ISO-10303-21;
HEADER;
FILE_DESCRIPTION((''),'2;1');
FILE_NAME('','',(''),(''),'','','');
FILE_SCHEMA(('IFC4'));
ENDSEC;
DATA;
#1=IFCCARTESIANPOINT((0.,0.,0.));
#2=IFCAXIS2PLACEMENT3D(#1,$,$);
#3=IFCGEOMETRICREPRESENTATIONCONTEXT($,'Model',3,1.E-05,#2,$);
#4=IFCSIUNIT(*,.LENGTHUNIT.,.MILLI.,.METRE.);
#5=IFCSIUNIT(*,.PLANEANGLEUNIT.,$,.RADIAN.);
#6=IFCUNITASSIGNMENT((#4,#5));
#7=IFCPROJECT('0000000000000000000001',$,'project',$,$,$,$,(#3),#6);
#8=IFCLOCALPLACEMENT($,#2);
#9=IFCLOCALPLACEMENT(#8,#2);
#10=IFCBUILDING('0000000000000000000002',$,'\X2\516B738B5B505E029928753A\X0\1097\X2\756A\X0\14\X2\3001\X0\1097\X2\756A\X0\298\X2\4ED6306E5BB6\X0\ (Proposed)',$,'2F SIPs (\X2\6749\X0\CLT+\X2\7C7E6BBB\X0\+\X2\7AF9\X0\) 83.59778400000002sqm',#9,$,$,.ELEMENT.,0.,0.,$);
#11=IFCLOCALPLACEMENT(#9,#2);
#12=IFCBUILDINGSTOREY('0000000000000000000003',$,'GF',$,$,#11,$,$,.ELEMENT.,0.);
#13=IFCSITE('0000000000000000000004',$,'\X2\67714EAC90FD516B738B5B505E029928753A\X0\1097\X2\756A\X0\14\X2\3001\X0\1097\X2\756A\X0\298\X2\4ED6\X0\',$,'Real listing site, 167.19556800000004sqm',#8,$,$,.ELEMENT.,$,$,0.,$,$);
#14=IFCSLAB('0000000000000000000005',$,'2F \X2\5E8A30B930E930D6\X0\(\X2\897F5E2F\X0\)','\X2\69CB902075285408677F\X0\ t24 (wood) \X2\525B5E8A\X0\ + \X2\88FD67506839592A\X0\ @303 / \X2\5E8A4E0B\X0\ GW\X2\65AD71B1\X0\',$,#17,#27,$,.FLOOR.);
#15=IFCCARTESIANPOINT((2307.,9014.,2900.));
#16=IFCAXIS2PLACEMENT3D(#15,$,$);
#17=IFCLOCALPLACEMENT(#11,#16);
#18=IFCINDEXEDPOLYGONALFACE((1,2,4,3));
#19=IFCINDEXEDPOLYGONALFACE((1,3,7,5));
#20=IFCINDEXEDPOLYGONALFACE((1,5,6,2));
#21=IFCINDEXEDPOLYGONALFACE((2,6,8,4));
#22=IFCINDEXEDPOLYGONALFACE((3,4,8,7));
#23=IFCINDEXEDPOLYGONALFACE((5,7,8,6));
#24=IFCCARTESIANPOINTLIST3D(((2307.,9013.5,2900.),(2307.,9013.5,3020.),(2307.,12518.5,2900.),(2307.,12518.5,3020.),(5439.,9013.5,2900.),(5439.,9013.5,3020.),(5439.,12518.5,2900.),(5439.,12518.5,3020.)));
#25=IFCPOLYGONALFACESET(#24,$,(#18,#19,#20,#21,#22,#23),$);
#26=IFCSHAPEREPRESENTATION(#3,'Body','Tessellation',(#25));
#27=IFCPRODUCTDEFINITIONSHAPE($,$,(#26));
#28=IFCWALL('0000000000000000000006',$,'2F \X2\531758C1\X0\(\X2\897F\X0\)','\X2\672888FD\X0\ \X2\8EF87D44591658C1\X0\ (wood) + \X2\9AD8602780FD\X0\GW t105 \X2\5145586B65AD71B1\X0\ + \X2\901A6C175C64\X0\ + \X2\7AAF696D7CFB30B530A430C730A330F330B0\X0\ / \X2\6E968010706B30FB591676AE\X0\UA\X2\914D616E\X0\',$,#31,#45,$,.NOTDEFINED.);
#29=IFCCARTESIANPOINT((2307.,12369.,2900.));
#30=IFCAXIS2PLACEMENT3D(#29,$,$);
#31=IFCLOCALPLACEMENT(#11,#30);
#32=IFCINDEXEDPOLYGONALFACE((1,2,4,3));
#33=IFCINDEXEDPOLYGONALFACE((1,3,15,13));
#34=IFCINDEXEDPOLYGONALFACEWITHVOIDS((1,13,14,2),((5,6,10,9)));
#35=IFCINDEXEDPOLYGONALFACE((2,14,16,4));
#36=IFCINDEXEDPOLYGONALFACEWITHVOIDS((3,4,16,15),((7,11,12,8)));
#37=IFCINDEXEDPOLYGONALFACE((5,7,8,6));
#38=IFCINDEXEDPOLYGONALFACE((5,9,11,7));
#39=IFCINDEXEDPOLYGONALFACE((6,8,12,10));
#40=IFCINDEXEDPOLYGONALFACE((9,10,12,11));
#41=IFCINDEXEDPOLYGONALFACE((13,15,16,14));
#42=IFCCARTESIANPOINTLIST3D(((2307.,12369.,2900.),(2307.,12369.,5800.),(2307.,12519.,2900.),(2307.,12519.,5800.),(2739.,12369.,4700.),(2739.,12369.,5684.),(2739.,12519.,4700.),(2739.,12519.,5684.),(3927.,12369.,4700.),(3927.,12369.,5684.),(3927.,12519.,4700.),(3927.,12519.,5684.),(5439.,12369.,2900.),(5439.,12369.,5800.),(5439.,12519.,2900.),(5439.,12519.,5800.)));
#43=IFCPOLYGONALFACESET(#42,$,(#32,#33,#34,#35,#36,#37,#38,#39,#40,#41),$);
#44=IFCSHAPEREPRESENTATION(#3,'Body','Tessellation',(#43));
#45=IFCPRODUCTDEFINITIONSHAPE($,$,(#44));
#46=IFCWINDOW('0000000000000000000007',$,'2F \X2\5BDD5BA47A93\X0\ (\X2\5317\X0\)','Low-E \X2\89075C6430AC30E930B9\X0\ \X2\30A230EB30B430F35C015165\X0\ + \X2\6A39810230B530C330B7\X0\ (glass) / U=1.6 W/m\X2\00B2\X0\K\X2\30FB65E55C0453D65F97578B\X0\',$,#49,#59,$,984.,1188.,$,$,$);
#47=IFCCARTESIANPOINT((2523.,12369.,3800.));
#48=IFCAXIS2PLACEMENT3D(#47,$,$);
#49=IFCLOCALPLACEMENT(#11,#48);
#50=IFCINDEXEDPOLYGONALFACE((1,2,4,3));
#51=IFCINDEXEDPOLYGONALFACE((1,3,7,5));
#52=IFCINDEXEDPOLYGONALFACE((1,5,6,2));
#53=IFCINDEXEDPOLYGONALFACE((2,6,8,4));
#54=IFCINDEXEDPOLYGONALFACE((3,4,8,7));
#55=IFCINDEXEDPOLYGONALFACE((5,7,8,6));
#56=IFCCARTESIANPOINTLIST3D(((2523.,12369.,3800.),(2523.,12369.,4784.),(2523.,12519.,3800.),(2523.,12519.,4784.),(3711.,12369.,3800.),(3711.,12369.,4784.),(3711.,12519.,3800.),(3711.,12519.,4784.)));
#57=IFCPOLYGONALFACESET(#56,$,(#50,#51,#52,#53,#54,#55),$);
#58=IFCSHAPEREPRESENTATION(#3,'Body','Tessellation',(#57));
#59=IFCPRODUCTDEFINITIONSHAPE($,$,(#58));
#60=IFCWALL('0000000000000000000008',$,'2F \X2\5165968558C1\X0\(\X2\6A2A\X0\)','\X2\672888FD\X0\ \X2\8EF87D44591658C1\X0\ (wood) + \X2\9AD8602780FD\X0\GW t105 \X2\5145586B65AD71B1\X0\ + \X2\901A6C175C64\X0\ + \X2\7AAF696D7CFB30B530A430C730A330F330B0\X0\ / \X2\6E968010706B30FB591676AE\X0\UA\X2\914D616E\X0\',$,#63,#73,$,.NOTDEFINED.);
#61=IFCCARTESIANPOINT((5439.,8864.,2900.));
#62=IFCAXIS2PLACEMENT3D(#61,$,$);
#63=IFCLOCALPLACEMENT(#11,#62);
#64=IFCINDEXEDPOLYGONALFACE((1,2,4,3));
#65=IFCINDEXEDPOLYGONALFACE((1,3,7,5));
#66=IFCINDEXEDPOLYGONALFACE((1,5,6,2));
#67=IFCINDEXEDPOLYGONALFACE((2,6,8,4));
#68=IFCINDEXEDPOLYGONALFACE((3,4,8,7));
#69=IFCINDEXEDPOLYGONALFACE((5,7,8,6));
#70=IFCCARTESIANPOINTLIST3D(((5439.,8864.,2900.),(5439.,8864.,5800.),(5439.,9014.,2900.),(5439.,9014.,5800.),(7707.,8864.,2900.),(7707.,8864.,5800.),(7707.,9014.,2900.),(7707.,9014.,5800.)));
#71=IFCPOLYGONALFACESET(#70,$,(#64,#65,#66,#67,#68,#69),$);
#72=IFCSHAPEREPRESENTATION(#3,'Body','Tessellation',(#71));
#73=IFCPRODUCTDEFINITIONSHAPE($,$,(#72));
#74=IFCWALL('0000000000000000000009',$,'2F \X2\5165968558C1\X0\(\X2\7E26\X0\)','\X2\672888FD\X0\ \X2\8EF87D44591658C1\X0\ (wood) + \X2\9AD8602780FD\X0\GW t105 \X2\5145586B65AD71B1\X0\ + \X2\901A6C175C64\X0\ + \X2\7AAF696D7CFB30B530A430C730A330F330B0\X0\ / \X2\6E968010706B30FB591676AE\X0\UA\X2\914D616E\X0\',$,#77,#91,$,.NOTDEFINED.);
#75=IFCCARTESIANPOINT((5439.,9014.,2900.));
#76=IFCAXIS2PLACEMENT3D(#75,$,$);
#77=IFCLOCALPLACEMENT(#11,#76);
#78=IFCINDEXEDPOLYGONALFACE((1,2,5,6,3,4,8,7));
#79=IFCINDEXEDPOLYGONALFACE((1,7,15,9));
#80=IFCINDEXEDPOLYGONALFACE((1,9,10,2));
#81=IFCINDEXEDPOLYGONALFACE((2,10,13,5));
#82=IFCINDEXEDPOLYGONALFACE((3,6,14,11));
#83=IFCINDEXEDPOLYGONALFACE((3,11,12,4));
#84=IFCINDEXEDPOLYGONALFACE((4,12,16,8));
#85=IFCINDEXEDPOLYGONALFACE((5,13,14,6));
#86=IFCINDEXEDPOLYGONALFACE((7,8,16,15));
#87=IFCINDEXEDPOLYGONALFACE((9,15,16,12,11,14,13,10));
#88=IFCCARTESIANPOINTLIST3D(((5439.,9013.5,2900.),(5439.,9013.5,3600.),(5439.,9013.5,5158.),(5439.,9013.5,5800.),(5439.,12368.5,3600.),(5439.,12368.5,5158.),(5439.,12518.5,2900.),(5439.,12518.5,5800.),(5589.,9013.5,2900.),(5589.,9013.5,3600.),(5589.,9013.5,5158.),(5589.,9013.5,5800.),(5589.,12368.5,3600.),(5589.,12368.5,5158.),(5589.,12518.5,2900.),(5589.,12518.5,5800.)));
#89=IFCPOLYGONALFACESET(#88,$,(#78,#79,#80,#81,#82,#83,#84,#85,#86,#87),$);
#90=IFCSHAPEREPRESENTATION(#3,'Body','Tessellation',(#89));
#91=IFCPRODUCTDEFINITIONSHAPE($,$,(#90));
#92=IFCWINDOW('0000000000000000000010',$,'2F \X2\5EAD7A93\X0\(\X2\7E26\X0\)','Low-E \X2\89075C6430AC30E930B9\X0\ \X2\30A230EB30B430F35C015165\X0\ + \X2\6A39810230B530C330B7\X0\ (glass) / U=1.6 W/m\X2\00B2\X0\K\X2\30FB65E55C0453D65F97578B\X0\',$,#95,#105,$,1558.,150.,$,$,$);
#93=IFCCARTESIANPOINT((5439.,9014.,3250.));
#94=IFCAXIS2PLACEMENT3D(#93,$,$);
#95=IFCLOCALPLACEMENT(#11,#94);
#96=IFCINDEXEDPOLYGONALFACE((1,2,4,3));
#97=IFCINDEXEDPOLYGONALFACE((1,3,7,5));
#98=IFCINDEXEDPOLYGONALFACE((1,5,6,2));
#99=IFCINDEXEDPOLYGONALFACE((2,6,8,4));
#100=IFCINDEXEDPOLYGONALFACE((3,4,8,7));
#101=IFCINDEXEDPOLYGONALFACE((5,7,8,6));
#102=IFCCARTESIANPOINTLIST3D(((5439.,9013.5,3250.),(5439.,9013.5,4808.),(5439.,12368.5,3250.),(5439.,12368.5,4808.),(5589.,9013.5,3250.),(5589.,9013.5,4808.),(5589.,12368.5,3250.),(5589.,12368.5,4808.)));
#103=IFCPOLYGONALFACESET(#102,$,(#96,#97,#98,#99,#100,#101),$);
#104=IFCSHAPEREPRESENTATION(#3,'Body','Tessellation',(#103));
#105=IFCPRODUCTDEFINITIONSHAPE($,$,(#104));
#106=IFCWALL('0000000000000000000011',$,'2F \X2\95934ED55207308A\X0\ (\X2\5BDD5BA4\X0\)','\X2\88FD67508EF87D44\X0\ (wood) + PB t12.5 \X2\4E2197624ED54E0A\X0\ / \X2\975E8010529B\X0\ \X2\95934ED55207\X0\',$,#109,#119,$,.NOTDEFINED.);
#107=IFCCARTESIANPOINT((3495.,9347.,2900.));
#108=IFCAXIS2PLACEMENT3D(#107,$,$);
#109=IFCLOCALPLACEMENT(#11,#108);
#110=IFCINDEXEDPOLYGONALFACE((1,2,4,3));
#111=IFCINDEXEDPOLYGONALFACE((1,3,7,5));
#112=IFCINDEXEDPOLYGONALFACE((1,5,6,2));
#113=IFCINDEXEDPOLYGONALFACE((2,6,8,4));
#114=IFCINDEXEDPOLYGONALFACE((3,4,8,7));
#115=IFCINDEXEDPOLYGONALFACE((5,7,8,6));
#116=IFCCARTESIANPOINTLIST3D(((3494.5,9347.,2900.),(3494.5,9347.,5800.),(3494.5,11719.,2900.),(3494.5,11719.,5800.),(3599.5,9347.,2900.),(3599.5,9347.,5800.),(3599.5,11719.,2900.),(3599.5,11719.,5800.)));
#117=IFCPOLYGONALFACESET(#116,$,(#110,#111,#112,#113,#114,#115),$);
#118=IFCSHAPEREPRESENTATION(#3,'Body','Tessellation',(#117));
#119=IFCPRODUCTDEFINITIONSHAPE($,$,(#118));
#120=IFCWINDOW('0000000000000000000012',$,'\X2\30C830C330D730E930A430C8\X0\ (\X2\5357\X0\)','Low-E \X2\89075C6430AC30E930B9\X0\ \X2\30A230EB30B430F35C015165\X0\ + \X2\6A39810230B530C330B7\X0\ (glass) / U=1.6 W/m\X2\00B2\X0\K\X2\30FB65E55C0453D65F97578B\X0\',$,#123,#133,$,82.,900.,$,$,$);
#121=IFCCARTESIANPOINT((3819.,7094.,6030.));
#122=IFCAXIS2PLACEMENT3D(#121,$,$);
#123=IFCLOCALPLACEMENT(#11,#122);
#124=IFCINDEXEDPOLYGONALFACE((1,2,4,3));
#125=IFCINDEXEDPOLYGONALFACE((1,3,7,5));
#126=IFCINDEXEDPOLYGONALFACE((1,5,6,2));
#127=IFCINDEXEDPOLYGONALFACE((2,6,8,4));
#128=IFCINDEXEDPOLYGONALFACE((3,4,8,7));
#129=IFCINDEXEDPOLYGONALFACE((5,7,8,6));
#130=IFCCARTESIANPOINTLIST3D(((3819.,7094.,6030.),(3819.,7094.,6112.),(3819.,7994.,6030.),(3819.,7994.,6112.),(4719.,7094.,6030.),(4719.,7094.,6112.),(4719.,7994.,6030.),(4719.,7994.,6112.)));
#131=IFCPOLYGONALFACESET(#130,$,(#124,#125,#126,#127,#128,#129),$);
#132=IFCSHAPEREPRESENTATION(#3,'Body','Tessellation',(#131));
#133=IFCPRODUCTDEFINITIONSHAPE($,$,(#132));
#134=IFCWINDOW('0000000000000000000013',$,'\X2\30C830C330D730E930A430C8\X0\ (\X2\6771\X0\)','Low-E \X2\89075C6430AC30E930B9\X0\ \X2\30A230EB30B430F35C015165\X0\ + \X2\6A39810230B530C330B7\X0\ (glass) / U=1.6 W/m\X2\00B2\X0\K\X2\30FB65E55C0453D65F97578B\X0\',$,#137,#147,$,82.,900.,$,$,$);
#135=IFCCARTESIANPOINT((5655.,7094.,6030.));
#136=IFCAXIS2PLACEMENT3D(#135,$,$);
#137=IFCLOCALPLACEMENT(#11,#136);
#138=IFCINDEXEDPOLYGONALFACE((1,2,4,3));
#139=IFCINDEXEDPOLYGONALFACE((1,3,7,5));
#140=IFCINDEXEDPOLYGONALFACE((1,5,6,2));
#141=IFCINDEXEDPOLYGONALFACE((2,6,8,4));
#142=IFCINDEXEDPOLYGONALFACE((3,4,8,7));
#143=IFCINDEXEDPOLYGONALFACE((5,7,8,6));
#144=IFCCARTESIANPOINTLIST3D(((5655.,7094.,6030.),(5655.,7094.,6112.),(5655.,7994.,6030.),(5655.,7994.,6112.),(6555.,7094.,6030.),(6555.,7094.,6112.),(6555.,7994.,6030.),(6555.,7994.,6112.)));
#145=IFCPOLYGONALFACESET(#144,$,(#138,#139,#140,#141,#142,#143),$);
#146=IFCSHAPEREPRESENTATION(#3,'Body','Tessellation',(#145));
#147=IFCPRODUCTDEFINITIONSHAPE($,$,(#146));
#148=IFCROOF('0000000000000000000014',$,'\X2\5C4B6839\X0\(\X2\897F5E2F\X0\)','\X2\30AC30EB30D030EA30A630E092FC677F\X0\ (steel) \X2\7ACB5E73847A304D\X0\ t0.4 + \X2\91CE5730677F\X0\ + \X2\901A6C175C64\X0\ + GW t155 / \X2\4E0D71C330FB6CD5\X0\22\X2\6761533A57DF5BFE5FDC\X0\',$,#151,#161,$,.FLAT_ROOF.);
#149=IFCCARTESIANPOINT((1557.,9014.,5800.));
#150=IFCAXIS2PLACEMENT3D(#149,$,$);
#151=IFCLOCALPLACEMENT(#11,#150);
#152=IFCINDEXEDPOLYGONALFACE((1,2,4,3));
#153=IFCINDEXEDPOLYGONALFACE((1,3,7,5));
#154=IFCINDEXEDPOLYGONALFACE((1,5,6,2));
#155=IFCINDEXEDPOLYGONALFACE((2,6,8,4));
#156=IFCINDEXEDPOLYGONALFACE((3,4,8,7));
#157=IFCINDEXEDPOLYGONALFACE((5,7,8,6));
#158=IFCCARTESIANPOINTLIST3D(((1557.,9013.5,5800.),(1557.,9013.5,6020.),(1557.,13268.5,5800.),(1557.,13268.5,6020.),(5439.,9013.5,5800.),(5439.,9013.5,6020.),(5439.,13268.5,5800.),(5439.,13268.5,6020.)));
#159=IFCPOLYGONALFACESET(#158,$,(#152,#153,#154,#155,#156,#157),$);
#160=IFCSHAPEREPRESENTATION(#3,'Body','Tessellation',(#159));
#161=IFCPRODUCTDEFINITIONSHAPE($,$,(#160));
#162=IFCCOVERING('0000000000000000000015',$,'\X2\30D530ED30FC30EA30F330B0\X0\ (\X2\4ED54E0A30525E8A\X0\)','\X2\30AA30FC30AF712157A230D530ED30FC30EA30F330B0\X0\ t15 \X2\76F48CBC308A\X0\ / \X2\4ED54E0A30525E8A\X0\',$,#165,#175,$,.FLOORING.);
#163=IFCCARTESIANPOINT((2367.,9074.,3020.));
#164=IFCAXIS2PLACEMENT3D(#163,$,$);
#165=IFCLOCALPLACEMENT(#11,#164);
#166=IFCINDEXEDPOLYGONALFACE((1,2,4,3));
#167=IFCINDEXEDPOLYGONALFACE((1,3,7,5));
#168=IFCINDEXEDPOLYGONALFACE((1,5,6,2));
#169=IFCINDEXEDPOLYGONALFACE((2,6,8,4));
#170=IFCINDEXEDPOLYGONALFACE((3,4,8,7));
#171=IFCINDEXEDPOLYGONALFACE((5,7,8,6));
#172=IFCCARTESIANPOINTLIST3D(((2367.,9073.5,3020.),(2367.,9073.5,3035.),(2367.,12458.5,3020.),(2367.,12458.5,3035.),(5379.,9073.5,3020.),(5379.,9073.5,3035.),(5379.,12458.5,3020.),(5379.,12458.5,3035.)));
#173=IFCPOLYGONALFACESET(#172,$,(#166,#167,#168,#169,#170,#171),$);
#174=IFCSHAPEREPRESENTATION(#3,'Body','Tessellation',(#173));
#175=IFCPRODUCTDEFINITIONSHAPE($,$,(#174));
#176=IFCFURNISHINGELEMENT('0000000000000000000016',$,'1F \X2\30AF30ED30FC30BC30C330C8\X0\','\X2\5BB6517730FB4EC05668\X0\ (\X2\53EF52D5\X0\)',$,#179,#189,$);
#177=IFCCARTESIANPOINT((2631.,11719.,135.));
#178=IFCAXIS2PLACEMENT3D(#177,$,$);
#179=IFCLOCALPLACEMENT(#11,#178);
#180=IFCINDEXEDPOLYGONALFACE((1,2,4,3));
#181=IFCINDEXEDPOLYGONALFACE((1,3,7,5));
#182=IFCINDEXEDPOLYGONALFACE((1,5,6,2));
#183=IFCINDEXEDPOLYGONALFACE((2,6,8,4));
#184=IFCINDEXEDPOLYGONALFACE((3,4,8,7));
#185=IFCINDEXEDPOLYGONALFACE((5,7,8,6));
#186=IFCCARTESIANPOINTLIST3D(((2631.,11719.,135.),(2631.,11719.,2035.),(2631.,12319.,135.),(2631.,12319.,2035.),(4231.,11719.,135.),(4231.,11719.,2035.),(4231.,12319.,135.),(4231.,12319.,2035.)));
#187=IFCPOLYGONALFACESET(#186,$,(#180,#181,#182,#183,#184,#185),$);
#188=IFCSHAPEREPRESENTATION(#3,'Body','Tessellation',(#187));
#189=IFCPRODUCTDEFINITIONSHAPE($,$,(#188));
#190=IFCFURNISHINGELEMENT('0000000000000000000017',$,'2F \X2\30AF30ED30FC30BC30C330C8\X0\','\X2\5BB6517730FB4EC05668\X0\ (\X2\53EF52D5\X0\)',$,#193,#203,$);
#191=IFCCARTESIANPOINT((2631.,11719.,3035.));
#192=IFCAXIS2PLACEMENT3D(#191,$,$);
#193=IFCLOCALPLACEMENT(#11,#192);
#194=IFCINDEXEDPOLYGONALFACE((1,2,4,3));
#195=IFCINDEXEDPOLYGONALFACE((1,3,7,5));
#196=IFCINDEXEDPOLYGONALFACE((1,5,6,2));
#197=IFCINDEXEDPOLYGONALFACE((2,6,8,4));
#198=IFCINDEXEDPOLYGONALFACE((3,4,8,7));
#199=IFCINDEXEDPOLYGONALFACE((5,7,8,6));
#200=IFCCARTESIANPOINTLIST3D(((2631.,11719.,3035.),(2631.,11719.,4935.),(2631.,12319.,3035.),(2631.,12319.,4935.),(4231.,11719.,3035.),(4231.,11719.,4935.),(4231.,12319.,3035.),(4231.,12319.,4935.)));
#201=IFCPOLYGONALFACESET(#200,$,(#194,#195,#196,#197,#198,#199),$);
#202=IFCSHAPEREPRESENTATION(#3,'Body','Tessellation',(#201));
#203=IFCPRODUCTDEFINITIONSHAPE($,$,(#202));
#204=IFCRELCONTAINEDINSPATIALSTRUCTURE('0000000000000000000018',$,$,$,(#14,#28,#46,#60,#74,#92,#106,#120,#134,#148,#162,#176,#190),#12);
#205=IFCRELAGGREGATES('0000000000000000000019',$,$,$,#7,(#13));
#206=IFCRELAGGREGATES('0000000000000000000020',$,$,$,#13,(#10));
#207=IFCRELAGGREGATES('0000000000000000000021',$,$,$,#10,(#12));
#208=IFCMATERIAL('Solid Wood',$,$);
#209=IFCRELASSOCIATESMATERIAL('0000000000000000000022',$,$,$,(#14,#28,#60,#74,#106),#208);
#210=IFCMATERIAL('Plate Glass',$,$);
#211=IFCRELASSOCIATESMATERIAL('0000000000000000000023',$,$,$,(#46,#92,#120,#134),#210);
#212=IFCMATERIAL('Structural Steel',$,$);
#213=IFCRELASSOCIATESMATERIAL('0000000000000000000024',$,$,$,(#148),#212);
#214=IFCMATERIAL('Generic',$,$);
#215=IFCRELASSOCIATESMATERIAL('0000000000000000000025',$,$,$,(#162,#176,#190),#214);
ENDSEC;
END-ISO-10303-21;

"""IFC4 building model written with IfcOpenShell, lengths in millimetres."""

from ifc_helpers import new_model, si_unit, frame, frame_2d, origin, place, context, project, spatial, rectangle, extrude, material, element, fill, save


model = new_model("IFC4")

# Units and contexts
model_context = context("Model", 3, precision=1e-05, world=origin())
ifc_project = project(units=[si_unit("LENGTHUNIT", "METRE", prefix="MILLI"), si_unit("PLANEANGLEUNIT", "RADIAN")], contexts=[model_context])

# Site, building, storey
site_placement = place(None, origin())
site = spatial("IfcSite", under=ifc_project, at=site_placement, Name="東京都八王子市館町1097番14、1097番298他", ObjectType="Real listing site, 167.19556800000004sqm", CompositionType="ELEMENT", RefElevation=0.0)
building_placement = place(site_placement, origin())
building = spatial("IfcBuilding", under=site, at=building_placement, Name="八王子市館町1097番14、1097番298他の家 (Proposed)", ObjectType="2F SIPs (杉CLT+籾殻+竹) 83.59778400000002sqm", CompositionType="ELEMENT", ElevationOfRefHeight=0.0, ElevationOfTerrain=0.0)
storey_placement = place(building_placement, origin())
storey = spatial("IfcBuildingStorey", under=building, at=storey_placement, Name="GF", CompositionType="ELEMENT", Elevation=0.0)

# Slab
ifc_material_1 = material(Name="Solid Wood")
slab_placement = place(storey_placement, frame((2307.0, 9014.0, 2900.0)))
element("IfcSlab", 1, at=slab_placement, inside=storey, material=ifc_material_1, Name="2F 床スラブ(西帯)", Description="構造用合板 t24 (wood) 剛床 + 製材根太 @303 / 床下 GW断熱", PredefinedType="FLOOR", context=model_context, shape_type="SweptSolid", body=[
    extrude(rectangle(XDim=3132.0, YDim=3505.0, at=frame_2d((1566.0, 1752.0))), frame((2307.0, 9014.0, 2900.0)), (0.0, 0.0, 1.0), 120.0),
])

# Wall, opening, window
wall_1_placement = place(storey_placement, frame((2307.0, 12369.0, 2900.0)))
wall_1 = element("IfcWall", 2, at=wall_1_placement, inside=storey, material=ifc_material_1, Name="2F 北壁(西)", Description="木製 軸組外壁 (wood) + 高性能GW t105 充填断熱 + 通気層 + 窯業系サイディング / 準耐火・外皮UA配慮", PredefinedType="NOTDEFINED", context=model_context, shape_type="SweptSolid", body=[
    extrude(rectangle(XDim=3132.0, YDim=150.0, at=frame_2d((1566.0, 75.0))), frame((2307.0, 12369.0, 2900.0)), (0.0, 0.0, 1.0), 2900.0),
])
opening_1_placement = place(storey_placement, frame((2523.0, 12369.0, 3800.0)))
opening_1 = element("IfcOpeningElement", 3, at=opening_1_placement, cuts=wall_1, PredefinedType="NOTDEFINED", context=model_context, shape_type="SweptSolid", body=[
    extrude(rectangle(XDim=1188.0, YDim=150.0, at=frame_2d((594.0, 75.0))), frame((2523.0, 12369.0, 3800.0)), (0.0, 0.0, 1.0), 984.0),
])
ifc_material_2 = material(Name="Plate Glass")
window_1_placement = place(storey_placement, frame((2523.0, 12369.0, 3800.0)))
window_1 = element("IfcWindow", 4, at=window_1_placement, inside=storey, material=ifc_material_2, Name="2F 寝室窓 (北)", Description="Low-E 複層ガラス アルゴン封入 + 樹脂サッシ (glass) / U=1.6 W/m²K・日射取得型", OverallHeight=984.0, OverallWidth=1188.0, context=model_context, shape_type="SweptSolid", body=[
    extrude(rectangle(XDim=1188.0, YDim=150.0, at=frame_2d((594.0, 75.0))), frame((2523.0, 12369.0, 3800.0)), (0.0, 0.0, 1.0), 984.0),
])
fill(opening_1, window_1)

# Wall
wall_2_placement = place(storey_placement, frame((5439.0, 8864.0, 2900.0)))
element("IfcWall", 5, at=wall_2_placement, inside=storey, material=ifc_material_1, Name="2F 入隅壁(横)", Description="木製 軸組外壁 (wood) + 高性能GW t105 充填断熱 + 通気層 + 窯業系サイディング / 準耐火・外皮UA配慮", PredefinedType="NOTDEFINED", context=model_context, shape_type="SweptSolid", body=[
    extrude(rectangle(XDim=2268.0, YDim=150.0, at=frame_2d((1134.0, 75.0))), frame((5439.0, 8864.0, 2900.0)), (0.0, 0.0, 1.0), 2900.0),
])

# Wall, opening, window
wall_3_placement = place(storey_placement, frame((5439.0, 9014.0, 2900.0)))
wall_3 = element("IfcWall", 6, at=wall_3_placement, inside=storey, material=ifc_material_1, Name="2F 入隅壁(縦)", Description="木製 軸組外壁 (wood) + 高性能GW t105 充填断熱 + 通気層 + 窯業系サイディング / 準耐火・外皮UA配慮", PredefinedType="NOTDEFINED", context=model_context, shape_type="SweptSolid", body=[
    extrude(rectangle(XDim=150.0, YDim=3505.0, at=frame_2d((75.0, 1752.0))), frame((5439.0, 9014.0, 2900.0)), (0.0, 0.0, 1.0), 2900.0),
])
opening_2_placement = place(storey_placement, frame((5439.0, 9014.0, 3250.0)))
opening_2 = element("IfcOpeningElement", 7, at=opening_2_placement, cuts=wall_3, PredefinedType="NOTDEFINED", context=model_context, shape_type="SweptSolid", body=[
    extrude(rectangle(XDim=150.0, YDim=3355.0, at=frame_2d((75.0, 1677.0))), frame((5439.0, 9014.0, 3250.0)), (0.0, 0.0, 1.0), 1558.0),
])
window_2_placement = place(storey_placement, frame((5439.0, 9014.0, 3250.0)))
window_2 = element("IfcWindow", 8, at=window_2_placement, inside=storey, material=ifc_material_2, Name="2F 庭窓(縦)", Description="Low-E 複層ガラス アルゴン封入 + 樹脂サッシ (glass) / U=1.6 W/m²K・日射取得型", OverallHeight=1558.0, OverallWidth=150.0, context=model_context, shape_type="SweptSolid", body=[
    extrude(rectangle(XDim=150.0, YDim=3355.0, at=frame_2d((75.0, 1677.0))), frame((5439.0, 9014.0, 3250.0)), (0.0, 0.0, 1.0), 1558.0),
])
fill(opening_2, window_2)

# Wall
wall_4_placement = place(storey_placement, frame((3495.0, 9347.0, 2900.0)))
element("IfcWall", 9, at=wall_4_placement, inside=storey, material=ifc_material_1, Name="2F 間仕切り (寝室)", Description="製材軸組 (wood) + PB t12.5 両面仕上 / 非耐力 間仕切", PredefinedType="NOTDEFINED", context=model_context, shape_type="SweptSolid", body=[
    extrude(rectangle(XDim=105.0, YDim=2372.0, at=frame_2d((52.0, 1186.0))), frame((3495.0, 9347.0, 2900.0)), (0.0, 0.0, 1.0), 2900.0),
])

# Windows
window_3_placement = place(storey_placement, frame((3819.0, 7094.0, 6030.0)))
element("IfcWindow", 10, at=window_3_placement, inside=storey, material=ifc_material_2, Name="トップライト (南)", Description="Low-E 複層ガラス アルゴン封入 + 樹脂サッシ (glass) / U=1.6 W/m²K・日射取得型", OverallHeight=82.0, OverallWidth=900.0, context=model_context, shape_type="SweptSolid", body=[
    extrude(rectangle(XDim=900.0, YDim=900.0, at=frame_2d((450.0, 450.0))), frame((3819.0, 7094.0, 6030.0)), (0.0, 0.0, 1.0), 82.0),
])
window_4_placement = place(storey_placement, frame((5655.0, 7094.0, 6030.0)))
element("IfcWindow", 11, at=window_4_placement, inside=storey, material=ifc_material_2, Name="トップライト (東)", Description="Low-E 複層ガラス アルゴン封入 + 樹脂サッシ (glass) / U=1.6 W/m²K・日射取得型", OverallHeight=82.0, OverallWidth=900.0, context=model_context, shape_type="SweptSolid", body=[
    extrude(rectangle(XDim=900.0, YDim=900.0, at=frame_2d((450.0, 450.0))), frame((5655.0, 7094.0, 6030.0)), (0.0, 0.0, 1.0), 82.0),
])

# Roof
ifc_material_3 = material(Name="Structural Steel")
for number, where, name in (
    (12, (1557.0, 9014.0, 5800.0), "屋根(西帯)"),
):
    element("IfcRoof", number, at=place(storey_placement, frame(where)), inside=storey, material=ifc_material_3, Name=name, Description="ガルバリウム鋼板 (steel) 立平葺き t0.4 + 野地板 + 通気層 + GW t155 / 不燃・法22条区域対応", PredefinedType="FLAT_ROOF", context=model_context, shape_type="SweptSolid", body=[
        extrude(rectangle(XDim=3882.0, YDim=4255.0, at=frame_2d((1941.0, 2127.0))), frame((1557.0, 9014.0, 5800.0)), (0.0, 0.0, 1.0), 220.0),
    ])

# Covering
ifc_material_4 = material(Name="Generic")
covering_placement = place(storey_placement, frame((2367.0, 9074.0, 3020.0)))
element("IfcCovering", 13, at=covering_placement, inside=storey, material=ifc_material_4, Name="フローリング (仕上げ床)", Description="オーク無垢フローリング t15 直貼り / 仕上げ床", PredefinedType="FLOORING", context=model_context, shape_type="SweptSolid", body=[
    extrude(rectangle(XDim=3012.0, YDim=3385.0, at=frame_2d((1506.0, 1692.0))), frame((2367.0, 9074.0, 3020.0)), (0.0, 0.0, 1.0), 15.0),
])

# Furnishing elements
furnishing_1_placement = place(storey_placement, frame((2631.0, 11719.0, 135.0)))
element("IfcFurnishingElement", 14, at=furnishing_1_placement, inside=storey, material=ifc_material_4, Name="1F クローゼット", Description="家具・什器 (可動)", context=model_context, shape_type="SweptSolid", body=[
    extrude(rectangle(XDim=1600.0, YDim=600.0, at=frame_2d((800.0, 300.0))), frame((2631.0, 11719.0, 135.0)), (0.0, 0.0, 1.0), 1900.0),
])
furnishing_2_placement = place(storey_placement, frame((2631.0, 11719.0, 3035.0)))
element("IfcFurnishingElement", 15, at=furnishing_2_placement, inside=storey, material=ifc_material_4, Name="2F クローゼット", Description="家具・什器 (可動)", context=model_context, shape_type="SweptSolid", body=[
    extrude(rectangle(XDim=1600.0, YDim=600.0, at=frame_2d((800.0, 300.0))), frame((2631.0, 11719.0, 3035.0)), (0.0, 0.0, 1.0), 1900.0),
])

save(model, "model.ifc")
